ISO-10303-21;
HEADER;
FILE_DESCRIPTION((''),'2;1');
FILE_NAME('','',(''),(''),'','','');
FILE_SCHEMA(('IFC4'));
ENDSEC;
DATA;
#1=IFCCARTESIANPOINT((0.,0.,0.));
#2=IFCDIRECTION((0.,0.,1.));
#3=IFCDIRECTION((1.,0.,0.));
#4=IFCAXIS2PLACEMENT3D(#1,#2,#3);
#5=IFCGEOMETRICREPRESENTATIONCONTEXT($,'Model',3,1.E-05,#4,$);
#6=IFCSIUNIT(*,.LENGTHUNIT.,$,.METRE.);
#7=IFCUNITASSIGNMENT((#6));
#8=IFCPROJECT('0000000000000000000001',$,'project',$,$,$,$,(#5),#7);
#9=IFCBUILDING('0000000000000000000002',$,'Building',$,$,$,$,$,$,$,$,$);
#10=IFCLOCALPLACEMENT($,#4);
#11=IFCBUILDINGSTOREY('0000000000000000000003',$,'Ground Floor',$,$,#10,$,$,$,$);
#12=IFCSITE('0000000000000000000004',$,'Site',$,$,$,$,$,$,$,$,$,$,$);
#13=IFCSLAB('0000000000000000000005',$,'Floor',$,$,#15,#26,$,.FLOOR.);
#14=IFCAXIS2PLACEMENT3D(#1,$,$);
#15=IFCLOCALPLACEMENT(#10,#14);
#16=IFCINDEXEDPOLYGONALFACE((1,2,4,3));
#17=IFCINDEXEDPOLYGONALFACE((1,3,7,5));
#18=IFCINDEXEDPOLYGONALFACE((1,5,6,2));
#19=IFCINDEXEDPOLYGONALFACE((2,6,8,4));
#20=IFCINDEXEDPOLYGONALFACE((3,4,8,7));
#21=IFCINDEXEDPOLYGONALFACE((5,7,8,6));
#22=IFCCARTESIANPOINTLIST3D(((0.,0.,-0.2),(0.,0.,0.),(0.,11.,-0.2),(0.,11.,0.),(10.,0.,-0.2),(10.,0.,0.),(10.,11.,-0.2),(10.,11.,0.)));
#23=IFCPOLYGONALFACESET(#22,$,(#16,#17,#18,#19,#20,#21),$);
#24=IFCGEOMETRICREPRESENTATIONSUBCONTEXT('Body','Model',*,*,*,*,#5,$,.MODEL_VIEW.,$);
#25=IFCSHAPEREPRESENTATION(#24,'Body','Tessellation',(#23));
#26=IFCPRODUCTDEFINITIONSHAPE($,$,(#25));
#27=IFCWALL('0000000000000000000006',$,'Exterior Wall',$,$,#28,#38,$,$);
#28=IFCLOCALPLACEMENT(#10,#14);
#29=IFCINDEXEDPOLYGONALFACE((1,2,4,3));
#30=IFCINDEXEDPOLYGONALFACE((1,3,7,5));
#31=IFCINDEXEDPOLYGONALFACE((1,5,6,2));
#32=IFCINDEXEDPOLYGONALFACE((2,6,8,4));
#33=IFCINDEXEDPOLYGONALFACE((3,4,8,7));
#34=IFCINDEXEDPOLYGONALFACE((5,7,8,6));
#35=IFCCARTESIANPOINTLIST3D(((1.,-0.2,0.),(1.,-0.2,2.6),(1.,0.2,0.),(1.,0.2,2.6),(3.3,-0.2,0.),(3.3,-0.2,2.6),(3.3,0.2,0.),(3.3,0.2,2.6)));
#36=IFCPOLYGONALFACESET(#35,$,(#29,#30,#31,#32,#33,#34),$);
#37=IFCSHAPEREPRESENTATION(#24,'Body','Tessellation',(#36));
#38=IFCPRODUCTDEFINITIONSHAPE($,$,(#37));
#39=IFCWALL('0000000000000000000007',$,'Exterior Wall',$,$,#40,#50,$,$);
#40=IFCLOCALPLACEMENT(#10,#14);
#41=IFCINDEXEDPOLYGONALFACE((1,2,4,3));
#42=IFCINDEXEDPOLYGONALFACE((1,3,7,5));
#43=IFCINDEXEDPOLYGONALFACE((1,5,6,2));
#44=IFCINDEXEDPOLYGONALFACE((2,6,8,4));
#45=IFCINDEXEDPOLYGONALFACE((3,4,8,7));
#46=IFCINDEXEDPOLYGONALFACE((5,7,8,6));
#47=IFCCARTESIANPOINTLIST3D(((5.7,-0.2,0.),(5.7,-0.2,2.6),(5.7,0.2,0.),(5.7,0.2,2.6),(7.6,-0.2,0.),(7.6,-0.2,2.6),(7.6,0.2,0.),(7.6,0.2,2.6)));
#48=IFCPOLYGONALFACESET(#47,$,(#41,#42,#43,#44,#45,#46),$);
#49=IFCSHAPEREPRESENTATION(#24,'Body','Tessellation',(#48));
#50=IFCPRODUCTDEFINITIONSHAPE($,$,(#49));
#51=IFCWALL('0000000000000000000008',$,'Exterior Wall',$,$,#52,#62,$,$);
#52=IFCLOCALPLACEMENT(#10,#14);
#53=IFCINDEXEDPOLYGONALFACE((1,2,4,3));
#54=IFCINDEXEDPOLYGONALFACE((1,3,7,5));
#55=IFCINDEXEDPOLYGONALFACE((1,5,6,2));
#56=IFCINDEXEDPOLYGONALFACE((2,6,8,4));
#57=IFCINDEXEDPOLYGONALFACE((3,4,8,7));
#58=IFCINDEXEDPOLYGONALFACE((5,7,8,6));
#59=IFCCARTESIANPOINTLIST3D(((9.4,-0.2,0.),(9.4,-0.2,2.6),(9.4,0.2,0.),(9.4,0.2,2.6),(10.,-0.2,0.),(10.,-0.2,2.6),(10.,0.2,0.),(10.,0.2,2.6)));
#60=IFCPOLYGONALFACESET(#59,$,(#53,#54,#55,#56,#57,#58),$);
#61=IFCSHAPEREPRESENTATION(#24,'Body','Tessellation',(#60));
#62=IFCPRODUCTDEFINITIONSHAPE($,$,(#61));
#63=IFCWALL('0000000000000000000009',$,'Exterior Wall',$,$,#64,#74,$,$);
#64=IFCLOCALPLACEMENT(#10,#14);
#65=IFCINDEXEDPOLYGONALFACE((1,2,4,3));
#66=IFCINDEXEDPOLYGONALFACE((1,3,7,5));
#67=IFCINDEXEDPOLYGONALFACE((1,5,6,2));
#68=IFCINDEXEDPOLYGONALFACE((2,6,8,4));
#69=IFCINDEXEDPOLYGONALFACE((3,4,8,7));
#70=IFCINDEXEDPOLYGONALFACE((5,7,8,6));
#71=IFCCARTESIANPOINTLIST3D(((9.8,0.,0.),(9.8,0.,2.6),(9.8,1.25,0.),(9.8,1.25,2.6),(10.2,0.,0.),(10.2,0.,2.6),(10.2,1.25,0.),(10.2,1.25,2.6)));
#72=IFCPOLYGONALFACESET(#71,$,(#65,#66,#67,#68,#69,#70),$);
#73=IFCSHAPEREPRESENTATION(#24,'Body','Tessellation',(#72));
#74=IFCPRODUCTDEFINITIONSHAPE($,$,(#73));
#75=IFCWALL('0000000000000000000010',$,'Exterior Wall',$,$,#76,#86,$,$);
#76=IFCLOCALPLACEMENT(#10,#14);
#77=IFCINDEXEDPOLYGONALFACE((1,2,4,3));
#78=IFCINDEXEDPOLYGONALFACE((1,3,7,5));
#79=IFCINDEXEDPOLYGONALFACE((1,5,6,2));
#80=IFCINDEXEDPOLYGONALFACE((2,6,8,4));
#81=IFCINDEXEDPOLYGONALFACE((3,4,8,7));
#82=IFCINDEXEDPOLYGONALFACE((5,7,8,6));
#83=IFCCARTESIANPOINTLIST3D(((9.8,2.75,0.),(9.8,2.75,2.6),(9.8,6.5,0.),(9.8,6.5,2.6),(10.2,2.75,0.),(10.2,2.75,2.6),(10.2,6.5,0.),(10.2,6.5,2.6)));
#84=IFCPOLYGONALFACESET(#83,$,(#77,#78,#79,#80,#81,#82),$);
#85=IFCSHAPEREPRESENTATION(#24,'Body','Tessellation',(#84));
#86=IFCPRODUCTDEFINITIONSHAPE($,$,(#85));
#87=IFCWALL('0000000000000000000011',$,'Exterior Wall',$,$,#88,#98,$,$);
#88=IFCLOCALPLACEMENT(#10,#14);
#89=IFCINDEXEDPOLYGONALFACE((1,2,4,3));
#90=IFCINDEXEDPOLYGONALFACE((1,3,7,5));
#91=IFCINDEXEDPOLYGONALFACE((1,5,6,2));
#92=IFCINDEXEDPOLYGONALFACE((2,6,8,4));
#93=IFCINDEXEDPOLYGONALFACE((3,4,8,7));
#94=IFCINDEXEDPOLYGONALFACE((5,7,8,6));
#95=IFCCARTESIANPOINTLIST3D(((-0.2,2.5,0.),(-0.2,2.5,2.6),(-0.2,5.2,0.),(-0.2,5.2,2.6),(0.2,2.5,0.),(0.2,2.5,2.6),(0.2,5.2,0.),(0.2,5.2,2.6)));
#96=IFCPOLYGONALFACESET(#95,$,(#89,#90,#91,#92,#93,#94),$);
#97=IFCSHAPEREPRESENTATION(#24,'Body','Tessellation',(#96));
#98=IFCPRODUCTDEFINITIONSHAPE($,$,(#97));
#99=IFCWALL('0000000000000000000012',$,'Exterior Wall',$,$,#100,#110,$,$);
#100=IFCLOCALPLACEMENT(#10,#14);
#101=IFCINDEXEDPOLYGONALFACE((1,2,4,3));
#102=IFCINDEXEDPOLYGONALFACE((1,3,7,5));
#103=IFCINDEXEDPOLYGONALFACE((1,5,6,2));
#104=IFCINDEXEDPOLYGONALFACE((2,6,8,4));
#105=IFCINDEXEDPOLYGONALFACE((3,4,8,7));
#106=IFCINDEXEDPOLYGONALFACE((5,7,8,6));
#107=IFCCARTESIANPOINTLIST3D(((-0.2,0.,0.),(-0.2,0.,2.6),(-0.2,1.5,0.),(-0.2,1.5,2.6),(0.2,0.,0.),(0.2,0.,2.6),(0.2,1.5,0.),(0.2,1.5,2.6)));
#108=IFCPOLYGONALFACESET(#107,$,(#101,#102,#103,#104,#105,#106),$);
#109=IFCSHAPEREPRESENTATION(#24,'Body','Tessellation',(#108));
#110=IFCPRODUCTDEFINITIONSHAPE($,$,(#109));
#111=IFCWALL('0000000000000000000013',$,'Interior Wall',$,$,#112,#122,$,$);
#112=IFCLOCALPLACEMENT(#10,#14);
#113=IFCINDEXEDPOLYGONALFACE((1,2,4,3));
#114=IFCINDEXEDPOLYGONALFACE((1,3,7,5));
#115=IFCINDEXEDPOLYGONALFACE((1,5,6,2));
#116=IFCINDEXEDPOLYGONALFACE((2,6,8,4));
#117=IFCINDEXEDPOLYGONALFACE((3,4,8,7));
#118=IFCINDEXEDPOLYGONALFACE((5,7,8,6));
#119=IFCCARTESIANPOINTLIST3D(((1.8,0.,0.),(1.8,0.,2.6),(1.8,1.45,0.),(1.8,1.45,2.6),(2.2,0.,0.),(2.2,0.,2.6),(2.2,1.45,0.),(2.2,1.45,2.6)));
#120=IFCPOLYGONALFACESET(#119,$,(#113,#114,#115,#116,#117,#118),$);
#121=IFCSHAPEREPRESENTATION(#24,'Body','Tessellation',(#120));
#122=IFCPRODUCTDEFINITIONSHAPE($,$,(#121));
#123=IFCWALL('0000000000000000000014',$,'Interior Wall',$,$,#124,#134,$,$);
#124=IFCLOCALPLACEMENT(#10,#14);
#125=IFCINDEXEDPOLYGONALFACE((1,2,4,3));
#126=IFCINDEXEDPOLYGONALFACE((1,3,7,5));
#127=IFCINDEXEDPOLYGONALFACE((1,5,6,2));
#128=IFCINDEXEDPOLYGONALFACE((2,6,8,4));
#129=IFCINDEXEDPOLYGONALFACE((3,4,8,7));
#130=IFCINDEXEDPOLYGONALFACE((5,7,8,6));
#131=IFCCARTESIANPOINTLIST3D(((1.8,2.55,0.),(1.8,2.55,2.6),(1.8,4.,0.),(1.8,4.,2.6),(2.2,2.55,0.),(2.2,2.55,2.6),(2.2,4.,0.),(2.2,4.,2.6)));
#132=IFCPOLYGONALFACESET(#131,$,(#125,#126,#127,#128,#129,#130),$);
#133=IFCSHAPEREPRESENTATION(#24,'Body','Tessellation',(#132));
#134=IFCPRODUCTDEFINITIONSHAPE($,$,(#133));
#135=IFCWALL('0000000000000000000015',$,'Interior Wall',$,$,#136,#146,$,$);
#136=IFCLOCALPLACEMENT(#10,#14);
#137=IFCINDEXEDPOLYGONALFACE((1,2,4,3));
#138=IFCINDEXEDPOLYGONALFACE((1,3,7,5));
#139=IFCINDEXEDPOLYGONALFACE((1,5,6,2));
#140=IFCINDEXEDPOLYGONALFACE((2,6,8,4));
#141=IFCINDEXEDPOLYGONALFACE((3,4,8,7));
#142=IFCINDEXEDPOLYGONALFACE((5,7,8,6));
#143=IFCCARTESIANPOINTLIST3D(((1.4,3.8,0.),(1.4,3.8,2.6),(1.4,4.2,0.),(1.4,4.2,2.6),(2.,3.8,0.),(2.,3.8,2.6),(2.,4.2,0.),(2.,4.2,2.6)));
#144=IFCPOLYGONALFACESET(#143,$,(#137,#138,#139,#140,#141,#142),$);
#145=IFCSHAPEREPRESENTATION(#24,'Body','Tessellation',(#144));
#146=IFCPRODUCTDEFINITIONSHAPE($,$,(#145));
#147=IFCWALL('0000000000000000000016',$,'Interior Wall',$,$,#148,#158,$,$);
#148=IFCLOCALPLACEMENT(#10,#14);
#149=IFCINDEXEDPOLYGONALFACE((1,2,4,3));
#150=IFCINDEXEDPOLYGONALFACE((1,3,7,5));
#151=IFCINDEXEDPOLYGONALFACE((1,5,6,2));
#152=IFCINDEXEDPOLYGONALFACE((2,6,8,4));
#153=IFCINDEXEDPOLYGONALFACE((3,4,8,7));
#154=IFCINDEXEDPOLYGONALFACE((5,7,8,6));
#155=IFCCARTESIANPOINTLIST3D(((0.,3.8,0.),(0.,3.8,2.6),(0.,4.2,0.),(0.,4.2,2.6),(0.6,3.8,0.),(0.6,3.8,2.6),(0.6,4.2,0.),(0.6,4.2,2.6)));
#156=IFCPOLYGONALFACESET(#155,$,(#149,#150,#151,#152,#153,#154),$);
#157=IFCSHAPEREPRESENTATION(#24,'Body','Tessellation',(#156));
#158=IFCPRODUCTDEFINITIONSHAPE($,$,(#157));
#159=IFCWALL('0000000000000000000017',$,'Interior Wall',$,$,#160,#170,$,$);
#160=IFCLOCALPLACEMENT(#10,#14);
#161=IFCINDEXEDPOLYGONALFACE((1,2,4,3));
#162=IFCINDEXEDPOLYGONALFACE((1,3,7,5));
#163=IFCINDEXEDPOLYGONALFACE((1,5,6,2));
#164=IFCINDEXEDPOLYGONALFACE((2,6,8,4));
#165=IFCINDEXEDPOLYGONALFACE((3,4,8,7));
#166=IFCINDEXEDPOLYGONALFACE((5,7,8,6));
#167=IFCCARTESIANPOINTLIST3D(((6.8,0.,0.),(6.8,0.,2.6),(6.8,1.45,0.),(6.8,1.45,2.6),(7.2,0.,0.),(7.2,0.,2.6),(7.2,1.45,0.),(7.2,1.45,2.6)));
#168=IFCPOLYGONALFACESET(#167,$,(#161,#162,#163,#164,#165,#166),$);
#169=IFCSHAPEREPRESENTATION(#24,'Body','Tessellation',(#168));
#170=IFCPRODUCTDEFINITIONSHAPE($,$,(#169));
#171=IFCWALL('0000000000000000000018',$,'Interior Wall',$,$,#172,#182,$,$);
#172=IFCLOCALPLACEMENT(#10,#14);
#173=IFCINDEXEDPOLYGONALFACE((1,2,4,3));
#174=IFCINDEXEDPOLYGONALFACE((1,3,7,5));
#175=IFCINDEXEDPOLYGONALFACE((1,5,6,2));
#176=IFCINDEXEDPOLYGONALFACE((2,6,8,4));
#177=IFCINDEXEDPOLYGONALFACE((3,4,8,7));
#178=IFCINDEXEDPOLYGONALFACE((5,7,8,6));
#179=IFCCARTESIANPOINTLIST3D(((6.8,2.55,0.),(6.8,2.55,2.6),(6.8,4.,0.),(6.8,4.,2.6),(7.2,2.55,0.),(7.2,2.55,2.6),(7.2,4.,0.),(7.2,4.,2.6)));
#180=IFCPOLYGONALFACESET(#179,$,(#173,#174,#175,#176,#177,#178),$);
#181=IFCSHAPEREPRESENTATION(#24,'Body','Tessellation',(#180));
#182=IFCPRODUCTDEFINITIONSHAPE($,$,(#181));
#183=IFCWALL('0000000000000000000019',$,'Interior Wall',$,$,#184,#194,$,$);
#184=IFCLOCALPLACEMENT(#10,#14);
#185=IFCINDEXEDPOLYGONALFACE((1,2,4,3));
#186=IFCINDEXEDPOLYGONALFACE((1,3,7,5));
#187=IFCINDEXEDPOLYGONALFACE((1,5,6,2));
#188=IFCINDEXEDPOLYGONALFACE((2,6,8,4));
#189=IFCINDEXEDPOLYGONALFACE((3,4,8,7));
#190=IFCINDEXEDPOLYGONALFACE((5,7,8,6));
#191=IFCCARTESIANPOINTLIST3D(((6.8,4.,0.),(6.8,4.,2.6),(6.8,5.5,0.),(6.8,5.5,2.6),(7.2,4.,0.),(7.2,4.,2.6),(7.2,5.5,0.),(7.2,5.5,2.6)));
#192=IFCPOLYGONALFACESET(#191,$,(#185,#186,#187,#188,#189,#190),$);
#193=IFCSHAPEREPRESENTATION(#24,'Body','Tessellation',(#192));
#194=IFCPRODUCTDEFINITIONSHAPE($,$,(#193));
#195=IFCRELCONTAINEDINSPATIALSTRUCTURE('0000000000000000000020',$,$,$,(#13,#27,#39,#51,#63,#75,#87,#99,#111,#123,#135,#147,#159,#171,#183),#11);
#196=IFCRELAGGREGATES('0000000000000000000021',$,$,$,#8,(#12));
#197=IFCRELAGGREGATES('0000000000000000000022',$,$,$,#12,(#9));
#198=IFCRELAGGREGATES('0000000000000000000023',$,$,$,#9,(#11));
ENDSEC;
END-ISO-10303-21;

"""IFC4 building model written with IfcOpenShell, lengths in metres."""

from ifc_helpers import new_model, si_unit, frame, origin_with_axes, place, context, subcontext, project, spatial, indexed_curve, outline, extrude, element, save


model = new_model("IFC4")

# Units and contexts
model_context = context("Model", 3, precision=1e-05, world=origin_with_axes())
body_context = subcontext(model_context, "Body", "Model", "MODEL_VIEW")
ifc_project = project(units=[si_unit("LENGTHUNIT", "METRE")], contexts=[model_context])

# Site, building, storey
site = spatial("IfcSite", under=ifc_project, Name="Site")
building = spatial("IfcBuilding", under=site, Name="Building")
storey_placement = place(None, origin_with_axes())
storey = spatial("IfcBuildingStorey", under=building, at=storey_placement, Name="Ground Floor")

# Slab
slab_placement = place(storey_placement, frame((0.0, 0.0, -0.2), z_axis=(0.0, 0.0, 1.0), x_axis=(1.0, 0.0, 0.0)))
element("IfcSlab", 1, at=slab_placement, inside=storey, Name="Floor", PredefinedType="FLOOR", context=body_context, shape_type="SweptSolid", body=[
    extrude(outline(indexed_curve([(0.0, 0.0), (10.0, 0.0), (10.0, 11.0), (0.0, 11.0)])), None, (0.0, 0.0, 1.0), 0.2),
])

# Walls
wall_1_placement = place(storey_placement, frame((1.0, 0.0, 0.0), z_axis=(0.0, 0.0, 1.0), x_axis=(1.0, 0.0, 0.0)))
element("IfcWall", 2, at=wall_1_placement, inside=storey, Name="Exterior Wall", context=body_context, shape_type="SweptSolid", body=[
    extrude(outline(indexed_curve([(0.0, 0.0), (0.0, 0.4), (2.3, 0.4), (2.3, 0.0), (0.0, 0.0)], self_intersect=False)), frame((0.0, -0.2, 0.0), z_axis=(0.0, 0.0, 1.0), x_axis=(1.0, 0.0, 0.0)), (0.0, 0.0, 1.0), 2.6),
])
wall_2_placement = place(storey_placement, frame((5.7, 0.0, 0.0), z_axis=(0.0, 0.0, 1.0), x_axis=(1.0, 0.0, 0.0)))
element("IfcWall", 3, at=wall_2_placement, inside=storey, Name="Exterior Wall", context=body_context, shape_type="SweptSolid", body=[
    extrude(outline(indexed_curve([(0.0, 0.0), (0.0, 0.4), (1.9, 0.4), (1.9, 0.0), (0.0, 0.0)], self_intersect=False)), frame((0.0, -0.2, 0.0), z_axis=(0.0, 0.0, 1.0), x_axis=(1.0, 0.0, 0.0)), (0.0, 0.0, 1.0), 2.6),
])
wall_3_placement = place(storey_placement, frame((9.4, 0.0, 0.0), z_axis=(0.0, 0.0, 1.0), x_axis=(1.0, 0.0, 0.0)))
element("IfcWall", 4, at=wall_3_placement, inside=storey, Name="Exterior Wall", context=body_context, shape_type="SweptSolid", body=[
    extrude(outline(indexed_curve([(0.0, 0.0), (0.0, 0.4), (0.6, 0.4), (0.6, 0.0), (0.0, 0.0)], self_intersect=False)), frame((0.0, -0.2, 0.0), z_axis=(0.0, 0.0, 1.0), x_axis=(1.0, 0.0, 0.0)), (0.0, 0.0, 1.0), 2.6),
])
wall_4_placement = place(storey_placement, frame((10.0, 0.0, 0.0), z_axis=(0.0, 0.0, 1.0), x_axis=(0.0, 1.0, 0.0)))
element("IfcWall", 5, at=wall_4_placement, inside=storey, Name="Exterior Wall", context=body_context, shape_type="SweptSolid", body=[
    extrude(outline(indexed_curve([(0.0, 0.0), (0.0, 0.4), (1.25, 0.4), (1.25, 0.0), (0.0, 0.0)], self_intersect=False)), frame((0.0, -0.2, 0.0), z_axis=(0.0, 0.0, 1.0), x_axis=(1.0, 0.0, 0.0)), (0.0, 0.0, 1.0), 2.6),
])
wall_5_placement = place(storey_placement, frame((10.0, 2.75, 0.0), z_axis=(0.0, 0.0, 1.0), x_axis=(0.0, 1.0, 0.0)))
element("IfcWall", 6, at=wall_5_placement, inside=storey, Name="Exterior Wall", context=body_context, shape_type="SweptSolid", body=[
    extrude(outline(indexed_curve([(0.0, 0.0), (0.0, 0.4), (3.75, 0.4), (3.75, 0.0), (0.0, 0.0)], self_intersect=False)), frame((0.0, -0.2, 0.0), z_axis=(0.0, 0.0, 1.0), x_axis=(1.0, 0.0, 0.0)), (0.0, 0.0, 1.0), 2.6),
])
wall_6_placement = place(storey_placement, frame((0.0, 5.2, 0.0), z_axis=(0.0, 0.0, 1.0), x_axis=(0.0, -1.0, 0.0)))
element("IfcWall", 7, at=wall_6_placement, inside=storey, Name="Exterior Wall", context=body_context, shape_type="SweptSolid", body=[
    extrude(outline(indexed_curve([(0.0, 0.0), (0.0, 0.4), (2.7, 0.4), (2.7, 0.0), (0.0, 0.0)], self_intersect=False)), frame((0.0, -0.2, 0.0), z_axis=(0.0, 0.0, 1.0), x_axis=(1.0, 0.0, 0.0)), (0.0, 0.0, 1.0), 2.6),
])
wall_7_placement = place(storey_placement, frame((0.0, 1.5, 0.0), z_axis=(0.0, 0.0, 1.0), x_axis=(0.0, -1.0, 0.0)))
element("IfcWall", 8, at=wall_7_placement, inside=storey, Name="Exterior Wall", context=body_context, shape_type="SweptSolid", body=[
    extrude(outline(indexed_curve([(0.0, 0.0), (0.0, 0.4), (1.5, 0.4), (1.5, 0.0), (0.0, 0.0)], self_intersect=False)), frame((0.0, -0.2, 0.0), z_axis=(0.0, 0.0, 1.0), x_axis=(1.0, 0.0, 0.0)), (0.0, 0.0, 1.0), 2.6),
])
wall_8_placement = place(storey_placement, frame((2.0, 0.0, 0.0), z_axis=(0.0, 0.0, 1.0), x_axis=(0.0, 1.0, 0.0)))
element("IfcWall", 9, at=wall_8_placement, inside=storey, Name="Interior Wall", context=body_context, shape_type="SweptSolid", body=[
    extrude(outline(indexed_curve([(0.0, 0.0), (0.0, 0.4), (1.45, 0.4), (1.45, 0.0), (0.0, 0.0)], self_intersect=False)), frame((0.0, -0.2, 0.0), z_axis=(0.0, 0.0, 1.0), x_axis=(1.0, 0.0, 0.0)), (0.0, 0.0, 1.0), 2.6),
])
wall_9_placement = place(storey_placement, frame((2.0, 2.55, 0.0), z_axis=(0.0, 0.0, 1.0), x_axis=(0.0, 1.0, 0.0)))
element("IfcWall", 10, at=wall_9_placement, inside=storey, Name="Interior Wall", context=body_context, shape_type="SweptSolid", body=[
    extrude(outline(indexed_curve([(0.0, 0.0), (0.0, 0.4), (1.45, 0.4), (1.45, 0.0), (0.0, 0.0)], self_intersect=False)), frame((0.0, -0.2, 0.0), z_axis=(0.0, 0.0, 1.0), x_axis=(1.0, 0.0, 0.0)), (0.0, 0.0, 1.0), 2.6),
])
for number, where, z_axis, x_axis, name in (
    (11, (2.0, 4.0, 0.0), (0.0, 0.0, 1.0), (-1.0, 0.0, 0.0), "Interior Wall"),
    (12, (0.6, 4.0, 0.0), (0.0, 0.0, 1.0), (-1.0, 0.0, 0.0), "Interior Wall"),
):
    element("IfcWall", number, at=place(storey_placement, frame(where, z_axis=z_axis, x_axis=x_axis)), inside=storey, Name=name, context=body_context, shape_type="SweptSolid", body=[
        extrude(outline(indexed_curve([(0.0, 0.0), (0.0, 0.4), (0.6, 0.4), (0.6, 0.0), (0.0, 0.0)], self_intersect=False)), frame((0.0, -0.2, 0.0), z_axis=(0.0, 0.0, 1.0), x_axis=(1.0, 0.0, 0.0)), (0.0, 0.0, 1.0), 2.6),
    ])
wall_10_placement = place(storey_placement, frame((7.0, 0.0, 0.0), z_axis=(0.0, 0.0, 1.0), x_axis=(0.0, 1.0, 0.0)))
element("IfcWall", 13, at=wall_10_placement, inside=storey, Name="Interior Wall", context=body_context, shape_type="SweptSolid", body=[
    extrude(outline(indexed_curve([(0.0, 0.0), (0.0, 0.4), (1.45, 0.4), (1.45, 0.0), (0.0, 0.0)], self_intersect=False)), frame((0.0, -0.2, 0.0), z_axis=(0.0, 0.0, 1.0), x_axis=(1.0, 0.0, 0.0)), (0.0, 0.0, 1.0), 2.6),
])
wall_11_placement = place(storey_placement, frame((7.0, 2.55, 0.0), z_axis=(0.0, 0.0, 1.0), x_axis=(0.0, 1.0, 0.0)))
element("IfcWall", 14, at=wall_11_placement, inside=storey, Name="Interior Wall", context=body_context, shape_type="SweptSolid", body=[
    extrude(outline(indexed_curve([(0.0, 0.0), (0.0, 0.4), (1.45, 0.4), (1.45, 0.0), (0.0, 0.0)], self_intersect=False)), frame((0.0, -0.2, 0.0), z_axis=(0.0, 0.0, 1.0), x_axis=(1.0, 0.0, 0.0)), (0.0, 0.0, 1.0), 2.6),
])
wall_12_placement = place(storey_placement, frame((7.0, 4.0, 0.0), z_axis=(0.0, 0.0, 1.0), x_axis=(0.0, 1.0, 0.0)))
element("IfcWall", 15, at=wall_12_placement, inside=storey, Name="Interior Wall", context=body_context, shape_type="SweptSolid", body=[
    extrude(outline(indexed_curve([(0.0, 0.0), (0.0, 0.4), (1.5, 0.4), (1.5, 0.0), (0.0, 0.0)], self_intersect=False)), frame((0.0, -0.2, 0.0), z_axis=(0.0, 0.0, 1.0), x_axis=(1.0, 0.0, 0.0)), (0.0, 0.0, 1.0), 2.6),
])

save(model, "model.ifc")
